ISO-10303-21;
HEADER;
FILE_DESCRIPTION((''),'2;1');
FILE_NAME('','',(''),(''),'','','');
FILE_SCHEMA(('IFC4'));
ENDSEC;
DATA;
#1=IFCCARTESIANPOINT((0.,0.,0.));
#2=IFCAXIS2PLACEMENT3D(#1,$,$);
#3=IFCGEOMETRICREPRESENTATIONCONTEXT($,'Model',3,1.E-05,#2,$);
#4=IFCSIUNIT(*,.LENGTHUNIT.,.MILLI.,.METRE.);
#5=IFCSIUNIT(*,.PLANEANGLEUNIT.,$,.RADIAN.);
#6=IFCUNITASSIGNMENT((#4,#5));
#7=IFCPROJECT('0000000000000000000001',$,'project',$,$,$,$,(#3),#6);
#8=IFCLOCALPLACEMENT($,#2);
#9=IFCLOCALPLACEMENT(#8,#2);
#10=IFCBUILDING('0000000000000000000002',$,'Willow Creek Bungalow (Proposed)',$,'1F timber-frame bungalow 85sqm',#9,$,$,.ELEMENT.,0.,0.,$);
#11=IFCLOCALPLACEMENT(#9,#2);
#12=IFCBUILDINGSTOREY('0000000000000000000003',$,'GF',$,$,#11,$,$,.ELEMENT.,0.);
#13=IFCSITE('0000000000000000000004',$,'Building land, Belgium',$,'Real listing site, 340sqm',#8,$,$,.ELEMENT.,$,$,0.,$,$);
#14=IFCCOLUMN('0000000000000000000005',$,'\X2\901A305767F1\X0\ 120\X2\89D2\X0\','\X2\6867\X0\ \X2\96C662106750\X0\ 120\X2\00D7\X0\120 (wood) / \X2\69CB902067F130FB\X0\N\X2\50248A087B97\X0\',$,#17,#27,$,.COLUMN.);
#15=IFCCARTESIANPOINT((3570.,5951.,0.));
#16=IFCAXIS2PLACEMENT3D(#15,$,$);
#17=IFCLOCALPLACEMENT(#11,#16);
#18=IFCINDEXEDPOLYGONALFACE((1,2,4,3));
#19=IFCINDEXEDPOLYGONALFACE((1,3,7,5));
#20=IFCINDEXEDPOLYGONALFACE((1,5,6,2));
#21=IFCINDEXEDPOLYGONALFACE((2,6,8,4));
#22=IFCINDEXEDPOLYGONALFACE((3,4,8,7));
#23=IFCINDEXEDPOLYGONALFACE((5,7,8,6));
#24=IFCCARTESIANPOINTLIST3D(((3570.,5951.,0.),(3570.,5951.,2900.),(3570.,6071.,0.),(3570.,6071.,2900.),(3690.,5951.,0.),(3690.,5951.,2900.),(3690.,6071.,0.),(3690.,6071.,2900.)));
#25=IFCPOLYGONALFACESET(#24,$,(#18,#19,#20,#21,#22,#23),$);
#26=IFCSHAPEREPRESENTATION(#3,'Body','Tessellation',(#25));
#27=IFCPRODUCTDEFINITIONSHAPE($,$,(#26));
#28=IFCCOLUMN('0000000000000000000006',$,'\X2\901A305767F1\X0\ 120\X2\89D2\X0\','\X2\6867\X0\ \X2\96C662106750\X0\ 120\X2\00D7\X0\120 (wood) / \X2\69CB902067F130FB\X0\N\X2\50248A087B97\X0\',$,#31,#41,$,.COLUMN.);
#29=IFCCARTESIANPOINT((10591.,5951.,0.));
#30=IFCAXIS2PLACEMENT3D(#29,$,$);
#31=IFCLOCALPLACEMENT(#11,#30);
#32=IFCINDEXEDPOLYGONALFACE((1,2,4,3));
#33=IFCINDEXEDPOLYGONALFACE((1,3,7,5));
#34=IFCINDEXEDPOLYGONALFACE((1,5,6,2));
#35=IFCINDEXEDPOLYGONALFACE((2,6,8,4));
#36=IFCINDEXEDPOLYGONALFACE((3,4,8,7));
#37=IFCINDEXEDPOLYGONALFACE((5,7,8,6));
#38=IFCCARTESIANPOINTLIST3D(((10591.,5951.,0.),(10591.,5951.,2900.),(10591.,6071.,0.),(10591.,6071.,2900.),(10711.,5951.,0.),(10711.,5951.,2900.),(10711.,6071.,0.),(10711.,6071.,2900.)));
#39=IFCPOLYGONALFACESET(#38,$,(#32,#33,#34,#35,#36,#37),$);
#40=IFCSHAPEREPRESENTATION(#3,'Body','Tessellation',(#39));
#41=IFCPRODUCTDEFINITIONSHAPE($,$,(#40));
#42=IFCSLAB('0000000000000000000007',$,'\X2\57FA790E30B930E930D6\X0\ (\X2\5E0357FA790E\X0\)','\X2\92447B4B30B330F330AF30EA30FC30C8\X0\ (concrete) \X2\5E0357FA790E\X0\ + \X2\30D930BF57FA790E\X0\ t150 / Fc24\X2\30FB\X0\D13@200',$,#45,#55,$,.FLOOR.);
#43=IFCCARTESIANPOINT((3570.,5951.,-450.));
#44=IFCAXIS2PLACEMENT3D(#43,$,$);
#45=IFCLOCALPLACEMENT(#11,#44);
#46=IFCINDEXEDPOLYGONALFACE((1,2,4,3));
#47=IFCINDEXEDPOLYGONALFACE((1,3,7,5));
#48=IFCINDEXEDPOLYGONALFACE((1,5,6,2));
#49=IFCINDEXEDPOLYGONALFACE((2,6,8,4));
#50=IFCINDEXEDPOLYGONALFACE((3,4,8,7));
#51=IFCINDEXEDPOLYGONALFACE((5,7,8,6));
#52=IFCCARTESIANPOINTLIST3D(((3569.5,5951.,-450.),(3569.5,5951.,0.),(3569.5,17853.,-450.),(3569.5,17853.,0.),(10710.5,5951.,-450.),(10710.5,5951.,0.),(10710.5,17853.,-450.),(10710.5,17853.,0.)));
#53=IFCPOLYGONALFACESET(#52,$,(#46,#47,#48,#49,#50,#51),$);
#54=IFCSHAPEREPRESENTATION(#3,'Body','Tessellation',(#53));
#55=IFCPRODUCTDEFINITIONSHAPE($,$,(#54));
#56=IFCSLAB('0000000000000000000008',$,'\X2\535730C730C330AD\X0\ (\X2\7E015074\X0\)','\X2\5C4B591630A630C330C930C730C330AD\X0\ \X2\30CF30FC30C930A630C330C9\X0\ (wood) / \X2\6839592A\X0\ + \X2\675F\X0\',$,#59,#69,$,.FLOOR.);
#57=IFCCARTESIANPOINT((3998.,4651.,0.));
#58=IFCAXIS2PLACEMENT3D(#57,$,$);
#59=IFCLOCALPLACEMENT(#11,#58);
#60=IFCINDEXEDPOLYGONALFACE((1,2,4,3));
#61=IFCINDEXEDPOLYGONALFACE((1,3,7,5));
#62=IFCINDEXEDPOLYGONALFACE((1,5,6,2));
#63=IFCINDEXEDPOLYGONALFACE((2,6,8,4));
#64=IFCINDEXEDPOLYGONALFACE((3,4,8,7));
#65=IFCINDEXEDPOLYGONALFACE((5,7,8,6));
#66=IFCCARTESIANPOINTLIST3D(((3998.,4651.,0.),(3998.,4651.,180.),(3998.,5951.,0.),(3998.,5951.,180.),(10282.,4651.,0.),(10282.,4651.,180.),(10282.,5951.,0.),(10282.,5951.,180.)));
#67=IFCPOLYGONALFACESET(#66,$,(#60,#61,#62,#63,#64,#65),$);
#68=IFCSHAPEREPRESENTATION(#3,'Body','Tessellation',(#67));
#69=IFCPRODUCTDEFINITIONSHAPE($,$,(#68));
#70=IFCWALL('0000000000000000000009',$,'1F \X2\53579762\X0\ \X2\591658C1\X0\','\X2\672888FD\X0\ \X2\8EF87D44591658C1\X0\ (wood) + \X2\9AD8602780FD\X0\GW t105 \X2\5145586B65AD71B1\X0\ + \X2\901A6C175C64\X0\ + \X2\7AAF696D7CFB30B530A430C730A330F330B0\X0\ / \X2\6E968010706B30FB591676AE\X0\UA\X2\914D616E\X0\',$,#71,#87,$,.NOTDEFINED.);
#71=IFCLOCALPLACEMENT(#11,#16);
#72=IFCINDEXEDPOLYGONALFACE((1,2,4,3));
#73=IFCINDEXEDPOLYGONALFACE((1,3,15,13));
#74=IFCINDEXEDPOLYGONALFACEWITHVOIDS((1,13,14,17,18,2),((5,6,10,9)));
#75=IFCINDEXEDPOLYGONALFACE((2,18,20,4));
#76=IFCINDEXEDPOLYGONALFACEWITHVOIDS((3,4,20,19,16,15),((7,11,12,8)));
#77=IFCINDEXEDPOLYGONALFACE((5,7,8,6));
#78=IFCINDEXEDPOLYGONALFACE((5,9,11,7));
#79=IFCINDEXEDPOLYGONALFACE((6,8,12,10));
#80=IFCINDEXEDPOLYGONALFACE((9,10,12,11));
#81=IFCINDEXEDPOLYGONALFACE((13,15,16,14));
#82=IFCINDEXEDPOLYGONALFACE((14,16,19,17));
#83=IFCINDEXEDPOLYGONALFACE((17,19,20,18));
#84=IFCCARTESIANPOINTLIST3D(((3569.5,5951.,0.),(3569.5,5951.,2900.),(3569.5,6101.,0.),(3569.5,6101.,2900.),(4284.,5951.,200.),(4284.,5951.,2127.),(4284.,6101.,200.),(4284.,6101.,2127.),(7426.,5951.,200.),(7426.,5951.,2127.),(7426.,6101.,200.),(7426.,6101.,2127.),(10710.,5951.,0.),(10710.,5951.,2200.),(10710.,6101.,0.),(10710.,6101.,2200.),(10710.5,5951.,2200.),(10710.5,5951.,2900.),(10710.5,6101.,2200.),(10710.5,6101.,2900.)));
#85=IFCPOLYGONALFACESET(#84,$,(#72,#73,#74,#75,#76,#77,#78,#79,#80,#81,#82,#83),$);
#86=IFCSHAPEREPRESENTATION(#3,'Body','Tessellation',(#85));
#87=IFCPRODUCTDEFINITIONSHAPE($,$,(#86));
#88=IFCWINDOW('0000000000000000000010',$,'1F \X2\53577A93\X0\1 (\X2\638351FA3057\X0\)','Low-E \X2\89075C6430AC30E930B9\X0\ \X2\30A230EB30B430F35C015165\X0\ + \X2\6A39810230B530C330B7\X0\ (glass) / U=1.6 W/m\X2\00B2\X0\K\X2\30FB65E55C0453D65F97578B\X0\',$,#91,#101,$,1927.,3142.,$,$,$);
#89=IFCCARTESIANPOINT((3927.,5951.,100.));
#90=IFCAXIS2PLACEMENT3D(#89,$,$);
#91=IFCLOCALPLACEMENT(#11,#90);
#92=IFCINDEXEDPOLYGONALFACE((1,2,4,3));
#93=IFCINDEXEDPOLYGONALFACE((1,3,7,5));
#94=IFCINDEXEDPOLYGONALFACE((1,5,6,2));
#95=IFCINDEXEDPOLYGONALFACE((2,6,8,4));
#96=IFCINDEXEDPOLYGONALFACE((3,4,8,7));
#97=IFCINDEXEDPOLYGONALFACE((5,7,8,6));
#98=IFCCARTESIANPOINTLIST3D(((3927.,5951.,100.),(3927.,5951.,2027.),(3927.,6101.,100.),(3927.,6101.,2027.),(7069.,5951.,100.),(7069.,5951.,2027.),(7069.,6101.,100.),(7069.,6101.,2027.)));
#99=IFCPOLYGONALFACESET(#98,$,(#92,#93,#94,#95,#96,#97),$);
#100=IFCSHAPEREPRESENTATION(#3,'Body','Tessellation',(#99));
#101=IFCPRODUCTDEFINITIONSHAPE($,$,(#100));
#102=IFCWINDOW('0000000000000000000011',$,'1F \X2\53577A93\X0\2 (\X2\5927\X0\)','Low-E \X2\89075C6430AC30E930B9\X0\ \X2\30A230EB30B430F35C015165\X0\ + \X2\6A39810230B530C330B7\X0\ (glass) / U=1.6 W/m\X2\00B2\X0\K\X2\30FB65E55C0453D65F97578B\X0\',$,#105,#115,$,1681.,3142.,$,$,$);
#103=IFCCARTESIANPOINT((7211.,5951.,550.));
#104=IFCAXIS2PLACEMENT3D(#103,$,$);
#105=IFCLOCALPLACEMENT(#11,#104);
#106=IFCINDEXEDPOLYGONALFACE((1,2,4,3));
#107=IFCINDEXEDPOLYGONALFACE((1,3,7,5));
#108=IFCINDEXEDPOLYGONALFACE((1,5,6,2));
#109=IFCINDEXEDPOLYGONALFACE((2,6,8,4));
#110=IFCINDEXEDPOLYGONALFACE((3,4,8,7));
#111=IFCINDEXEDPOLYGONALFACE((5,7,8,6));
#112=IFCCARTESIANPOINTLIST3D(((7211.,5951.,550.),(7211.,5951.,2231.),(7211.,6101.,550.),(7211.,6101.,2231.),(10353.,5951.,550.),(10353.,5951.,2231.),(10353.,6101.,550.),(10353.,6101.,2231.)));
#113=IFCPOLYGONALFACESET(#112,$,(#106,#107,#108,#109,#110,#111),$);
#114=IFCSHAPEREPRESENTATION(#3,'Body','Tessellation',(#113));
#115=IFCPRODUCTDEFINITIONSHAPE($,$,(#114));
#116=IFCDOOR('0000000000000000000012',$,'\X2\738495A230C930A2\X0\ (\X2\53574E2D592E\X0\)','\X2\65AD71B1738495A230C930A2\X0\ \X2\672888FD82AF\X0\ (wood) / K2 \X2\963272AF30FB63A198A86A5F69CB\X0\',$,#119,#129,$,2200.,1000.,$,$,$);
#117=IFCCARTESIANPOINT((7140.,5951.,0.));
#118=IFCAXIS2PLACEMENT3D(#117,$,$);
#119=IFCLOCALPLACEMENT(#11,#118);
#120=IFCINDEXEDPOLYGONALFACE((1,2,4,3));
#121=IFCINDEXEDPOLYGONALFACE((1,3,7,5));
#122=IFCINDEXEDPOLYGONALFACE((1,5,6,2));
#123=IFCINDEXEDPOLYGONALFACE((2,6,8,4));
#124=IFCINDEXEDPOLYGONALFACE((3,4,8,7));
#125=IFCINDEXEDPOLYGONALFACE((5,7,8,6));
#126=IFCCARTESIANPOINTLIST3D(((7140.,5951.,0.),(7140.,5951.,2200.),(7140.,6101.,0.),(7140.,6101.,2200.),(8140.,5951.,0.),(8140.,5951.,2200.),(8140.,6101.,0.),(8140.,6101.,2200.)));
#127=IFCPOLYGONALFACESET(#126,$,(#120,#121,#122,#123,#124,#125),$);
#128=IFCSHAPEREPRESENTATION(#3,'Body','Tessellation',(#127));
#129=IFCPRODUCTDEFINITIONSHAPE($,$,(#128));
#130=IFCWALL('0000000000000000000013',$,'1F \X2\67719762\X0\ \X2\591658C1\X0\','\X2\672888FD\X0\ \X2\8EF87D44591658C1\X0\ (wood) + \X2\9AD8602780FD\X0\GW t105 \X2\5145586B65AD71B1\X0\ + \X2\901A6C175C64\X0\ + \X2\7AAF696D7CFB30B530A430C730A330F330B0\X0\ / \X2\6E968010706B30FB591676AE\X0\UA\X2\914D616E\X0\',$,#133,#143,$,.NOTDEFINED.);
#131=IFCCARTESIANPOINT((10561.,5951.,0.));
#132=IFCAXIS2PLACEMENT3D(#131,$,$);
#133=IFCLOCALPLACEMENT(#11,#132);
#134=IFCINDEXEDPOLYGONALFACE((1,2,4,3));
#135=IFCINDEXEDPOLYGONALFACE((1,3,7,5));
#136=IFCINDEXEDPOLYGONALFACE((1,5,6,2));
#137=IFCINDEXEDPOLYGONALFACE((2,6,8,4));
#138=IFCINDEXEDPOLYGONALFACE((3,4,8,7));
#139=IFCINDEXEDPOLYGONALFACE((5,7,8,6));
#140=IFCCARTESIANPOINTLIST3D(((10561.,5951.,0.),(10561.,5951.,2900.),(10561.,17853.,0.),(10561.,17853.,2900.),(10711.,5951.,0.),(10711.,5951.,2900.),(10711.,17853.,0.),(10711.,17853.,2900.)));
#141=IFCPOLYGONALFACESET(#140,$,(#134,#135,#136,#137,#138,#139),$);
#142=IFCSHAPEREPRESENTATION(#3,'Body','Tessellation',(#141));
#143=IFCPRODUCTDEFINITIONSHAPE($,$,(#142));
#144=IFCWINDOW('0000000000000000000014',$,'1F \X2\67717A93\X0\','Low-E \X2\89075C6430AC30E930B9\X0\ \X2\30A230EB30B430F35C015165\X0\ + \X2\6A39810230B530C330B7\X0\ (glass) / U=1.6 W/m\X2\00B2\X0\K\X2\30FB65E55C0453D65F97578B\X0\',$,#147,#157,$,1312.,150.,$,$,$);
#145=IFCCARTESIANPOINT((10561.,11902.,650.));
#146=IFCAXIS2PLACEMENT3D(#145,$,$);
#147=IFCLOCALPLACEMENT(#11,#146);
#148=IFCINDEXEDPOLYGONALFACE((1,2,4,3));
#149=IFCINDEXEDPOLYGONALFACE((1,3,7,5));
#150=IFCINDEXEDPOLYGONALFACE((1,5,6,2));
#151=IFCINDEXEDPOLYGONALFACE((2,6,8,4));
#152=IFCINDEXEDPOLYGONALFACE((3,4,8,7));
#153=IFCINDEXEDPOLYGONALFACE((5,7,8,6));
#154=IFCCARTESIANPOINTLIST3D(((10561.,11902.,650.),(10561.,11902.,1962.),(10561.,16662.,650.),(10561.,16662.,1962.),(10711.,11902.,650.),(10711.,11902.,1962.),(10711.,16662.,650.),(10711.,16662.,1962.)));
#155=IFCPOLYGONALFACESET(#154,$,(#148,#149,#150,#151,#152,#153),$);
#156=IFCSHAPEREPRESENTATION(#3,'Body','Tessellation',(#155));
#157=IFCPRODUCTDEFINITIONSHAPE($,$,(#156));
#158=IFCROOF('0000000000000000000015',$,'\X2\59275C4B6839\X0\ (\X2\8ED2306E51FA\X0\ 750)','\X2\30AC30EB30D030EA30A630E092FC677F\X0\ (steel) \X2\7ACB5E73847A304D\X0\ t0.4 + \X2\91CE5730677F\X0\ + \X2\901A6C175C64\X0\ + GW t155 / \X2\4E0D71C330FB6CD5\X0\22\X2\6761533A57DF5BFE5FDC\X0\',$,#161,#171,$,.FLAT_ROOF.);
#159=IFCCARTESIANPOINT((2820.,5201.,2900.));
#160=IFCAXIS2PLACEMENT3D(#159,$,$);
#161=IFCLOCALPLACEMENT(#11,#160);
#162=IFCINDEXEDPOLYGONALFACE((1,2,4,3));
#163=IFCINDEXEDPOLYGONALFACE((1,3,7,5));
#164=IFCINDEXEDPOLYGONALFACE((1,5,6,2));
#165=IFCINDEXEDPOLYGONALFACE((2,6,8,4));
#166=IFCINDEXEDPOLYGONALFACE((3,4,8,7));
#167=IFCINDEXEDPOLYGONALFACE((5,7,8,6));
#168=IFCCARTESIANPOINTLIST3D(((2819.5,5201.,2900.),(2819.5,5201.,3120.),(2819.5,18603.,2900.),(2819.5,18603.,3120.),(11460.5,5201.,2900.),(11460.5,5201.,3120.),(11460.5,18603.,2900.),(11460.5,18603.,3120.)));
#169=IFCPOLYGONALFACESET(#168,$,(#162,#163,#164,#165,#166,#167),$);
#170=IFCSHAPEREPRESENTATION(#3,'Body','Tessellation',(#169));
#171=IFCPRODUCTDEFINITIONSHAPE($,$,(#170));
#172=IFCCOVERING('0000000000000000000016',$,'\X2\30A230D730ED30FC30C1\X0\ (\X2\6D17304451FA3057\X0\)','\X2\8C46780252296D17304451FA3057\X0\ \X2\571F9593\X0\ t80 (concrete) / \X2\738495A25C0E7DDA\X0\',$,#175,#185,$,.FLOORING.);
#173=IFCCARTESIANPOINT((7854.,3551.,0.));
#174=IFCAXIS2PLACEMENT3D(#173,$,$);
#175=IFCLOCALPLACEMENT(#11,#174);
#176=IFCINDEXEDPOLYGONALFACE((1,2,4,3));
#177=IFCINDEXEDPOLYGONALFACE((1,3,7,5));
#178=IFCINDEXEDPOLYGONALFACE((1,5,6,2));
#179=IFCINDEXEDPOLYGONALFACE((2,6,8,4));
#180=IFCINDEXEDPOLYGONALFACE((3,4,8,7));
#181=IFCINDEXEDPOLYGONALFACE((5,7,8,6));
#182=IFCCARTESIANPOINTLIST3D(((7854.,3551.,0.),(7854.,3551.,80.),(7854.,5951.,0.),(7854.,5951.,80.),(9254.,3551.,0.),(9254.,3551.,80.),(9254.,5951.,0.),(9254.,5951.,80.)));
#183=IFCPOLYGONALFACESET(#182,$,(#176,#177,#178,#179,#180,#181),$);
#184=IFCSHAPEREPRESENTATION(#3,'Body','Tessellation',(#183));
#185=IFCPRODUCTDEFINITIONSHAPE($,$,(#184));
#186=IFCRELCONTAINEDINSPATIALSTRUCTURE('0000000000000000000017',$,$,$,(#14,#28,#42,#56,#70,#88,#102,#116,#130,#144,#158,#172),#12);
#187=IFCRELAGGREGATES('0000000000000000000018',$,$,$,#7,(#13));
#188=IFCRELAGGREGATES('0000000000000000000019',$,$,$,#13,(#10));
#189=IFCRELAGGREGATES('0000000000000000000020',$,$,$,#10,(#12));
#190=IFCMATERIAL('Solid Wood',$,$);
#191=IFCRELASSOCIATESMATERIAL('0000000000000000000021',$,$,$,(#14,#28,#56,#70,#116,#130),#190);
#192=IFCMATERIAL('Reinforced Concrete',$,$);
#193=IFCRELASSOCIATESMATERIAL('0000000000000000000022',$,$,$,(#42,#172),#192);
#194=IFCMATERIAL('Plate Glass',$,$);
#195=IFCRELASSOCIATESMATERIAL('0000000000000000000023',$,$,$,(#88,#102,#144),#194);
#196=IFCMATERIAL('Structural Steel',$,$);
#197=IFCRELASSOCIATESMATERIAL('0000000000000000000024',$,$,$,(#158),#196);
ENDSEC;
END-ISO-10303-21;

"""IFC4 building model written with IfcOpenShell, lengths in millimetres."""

from ifc_helpers import new_model, si_unit, frame, frame_2d, origin, place, context, project, spatial, rectangle, extrude, material, element, fill, save


model = new_model("IFC4")

# Units and contexts
model_context = context("Model", 3, precision=1e-05, world=origin())
ifc_project = project(units=[si_unit("LENGTHUNIT", "METRE", prefix="MILLI"), si_unit("PLANEANGLEUNIT", "RADIAN")], contexts=[model_context])

# Site, building, storey
site_placement = place(None, origin())
site = spatial("IfcSite", under=ifc_project, at=site_placement, Name="Building land, Belgium", ObjectType="Real listing site, 340sqm", CompositionType="ELEMENT", RefElevation=0.0)
building_placement = place(site_placement, origin())
building = spatial("IfcBuilding", under=site, at=building_placement, Name="Willow Creek Bungalow (Proposed)", ObjectType="1F timber-frame bungalow 85sqm", CompositionType="ELEMENT", ElevationOfRefHeight=0.0, ElevationOfTerrain=0.0)
storey_placement = place(building_placement, origin())
storey = spatial("IfcBuildingStorey", under=building, at=storey_placement, Name="GF", CompositionType="ELEMENT", Elevation=0.0)

# Columns
ifc_material_1 = material(Name="Solid Wood")
column_1_placement = place(storey_placement, frame((3570.0, 5951.0, 0.0)))
element("IfcColumn", 1, at=column_1_placement, inside=storey, material=ifc_material_1, Name="通し柱 120角", Description="桧 集成材 120×120 (wood) / 構造柱・N値計算", PredefinedType="COLUMN", context=model_context, shape_type="SweptSolid", body=[
    extrude(rectangle(XDim=120.0, YDim=120.0, at=frame_2d((60.0, 60.0))), frame((3570.0, 5951.0, 0.0)), (0.0, 0.0, 1.0), 2900.0),
])
column_2_placement = place(storey_placement, frame((10591.0, 5951.0, 0.0)))
element("IfcColumn", 2, at=column_2_placement, inside=storey, material=ifc_material_1, Name="通し柱 120角", Description="桧 集成材 120×120 (wood) / 構造柱・N値計算", PredefinedType="COLUMN", context=model_context, shape_type="SweptSolid", body=[
    extrude(rectangle(XDim=120.0, YDim=120.0, at=frame_2d((60.0, 60.0))), frame((10591.0, 5951.0, 0.0)), (0.0, 0.0, 1.0), 2900.0),
])

# Slabs
ifc_material_2 = material(Name="Reinforced Concrete")
slab_1_placement = place(storey_placement, frame((3570.0, 5951.0, -450.0)))
element("IfcSlab", 3, at=slab_1_placement, inside=storey, material=ifc_material_2, Name="基礎スラブ (布基礎)", Description="鉄筋コンクリート (concrete) 布基礎 + ベタ基礎 t150 / Fc24・D13@200", PredefinedType="FLOOR", context=model_context, shape_type="SweptSolid", body=[
    extrude(rectangle(XDim=7141.0, YDim=11902.0, at=frame_2d((3570.0, 5951.0))), frame((3570.0, 5951.0, -450.0)), (0.0, 0.0, 1.0), 450.0),
])
slab_2_placement = place(storey_placement, frame((3998.0, 4651.0, 0.0)))
element("IfcSlab", 4, at=slab_2_placement, inside=storey, material=ifc_material_1, Name="南デッキ (縁側)", Description="屋外ウッドデッキ ハードウッド (wood) / 根太 + 束", PredefinedType="FLOOR", context=model_context, shape_type="SweptSolid", body=[
    extrude(rectangle(XDim=6284.0, YDim=1300.0, at=frame_2d((3142.0, 650.0))), frame((3998.0, 4651.0, 0.0)), (0.0, 0.0, 1.0), 180.0),
])

# Wall, openings, windows, door
wall_1_placement = place(storey_placement, frame((3570.0, 5951.0, 0.0)))
wall_1 = element("IfcWall", 5, at=wall_1_placement, inside=storey, material=ifc_material_1, Name="1F 南面 外壁", Description="木製 軸組外壁 (wood) + 高性能GW t105 充填断熱 + 通気層 + 窯業系サイディング / 準耐火・外皮UA配慮", PredefinedType="NOTDEFINED", context=model_context, shape_type="SweptSolid", body=[
    extrude(rectangle(XDim=7141.0, YDim=150.0, at=frame_2d((3570.0, 75.0))), frame((3570.0, 5951.0, 0.0)), (0.0, 0.0, 1.0), 2900.0),
])
opening_1_placement = place(storey_placement, frame((3927.0, 5951.0, 100.0)))
opening_1 = element("IfcOpeningElement", 6, at=opening_1_placement, cuts=wall_1, PredefinedType="NOTDEFINED", context=model_context, shape_type="SweptSolid", body=[
    extrude(rectangle(XDim=3142.0, YDim=150.0, at=frame_2d((1571.0, 75.0))), frame((3927.0, 5951.0, 100.0)), (0.0, 0.0, 1.0), 1927.0),
])
opening_2_placement = place(storey_placement, frame((7211.0, 5951.0, 550.0)))
opening_2 = element("IfcOpeningElement", 7, at=opening_2_placement, cuts=wall_1, PredefinedType="NOTDEFINED", context=model_context, shape_type="SweptSolid", body=[
    extrude(rectangle(XDim=3142.0, YDim=150.0, at=frame_2d((1571.0, 75.0))), frame((7211.0, 5951.0, 550.0)), (0.0, 0.0, 1.0), 1681.0),
])
opening_3_placement = place(storey_placement, frame((7140.0, 5951.0, 0.0)))
opening_3 = element("IfcOpeningElement", 8, at=opening_3_placement, cuts=wall_1, PredefinedType="NOTDEFINED", context=model_context, shape_type="SweptSolid", body=[
    extrude(rectangle(XDim=1000.0, YDim=150.0, at=frame_2d((500.0, 75.0))), frame((7140.0, 5951.0, 0.0)), (0.0, 0.0, 1.0), 2200.0),
])
ifc_material_3 = material(Name="Plate Glass")
window_1_placement = place(storey_placement, frame((3927.0, 5951.0, 100.0)))
window_1 = element("IfcWindow", 9, at=window_1_placement, inside=storey, material=ifc_material_3, Name="1F 南窓1 (掃出し)", Description="Low-E 複層ガラス アルゴン封入 + 樹脂サッシ (glass) / U=1.6 W/m²K・日射取得型", OverallHeight=1927.0, OverallWidth=3142.0, context=model_context, shape_type="SweptSolid", body=[
    extrude(rectangle(XDim=3142.0, YDim=150.0, at=frame_2d((1571.0, 75.0))), frame((3927.0, 5951.0, 100.0)), (0.0, 0.0, 1.0), 1927.0),
])
fill(opening_1, window_1)
window_2_placement = place(storey_placement, frame((7211.0, 5951.0, 550.0)))
window_2 = element("IfcWindow", 10, at=window_2_placement, inside=storey, material=ifc_material_3, Name="1F 南窓2 (大)", Description="Low-E 複層ガラス アルゴン封入 + 樹脂サッシ (glass) / U=1.6 W/m²K・日射取得型", OverallHeight=1681.0, OverallWidth=3142.0, context=model_context, shape_type="SweptSolid", body=[
    extrude(rectangle(XDim=3142.0, YDim=150.0, at=frame_2d((1571.0, 75.0))), frame((7211.0, 5951.0, 550.0)), (0.0, 0.0, 1.0), 1681.0),
])
fill(opening_2, window_2)
door_placement = place(storey_placement, frame((7140.0, 5951.0, 0.0)))
door = element("IfcDoor", 11, at=door_placement, inside=storey, material=ifc_material_1, Name="玄関ドア (南中央)", Description="断熱玄関ドア 木製芯 (wood) / K2 防犯・採風機構", OverallHeight=2200.0, OverallWidth=1000.0, context=model_context, shape_type="SweptSolid", body=[
    extrude(rectangle(XDim=1000.0, YDim=150.0, at=frame_2d((500.0, 75.0))), frame((7140.0, 5951.0, 0.0)), (0.0, 0.0, 1.0), 2200.0),
])
fill(opening_3, door)

# Wall, opening, window
wall_2_placement = place(storey_placement, frame((10561.0, 5951.0, 0.0)))
wall_2 = element("IfcWall", 12, at=wall_2_placement, inside=storey, material=ifc_material_1, Name="1F 東面 外壁", Description="木製 軸組外壁 (wood) + 高性能GW t105 充填断熱 + 通気層 + 窯業系サイディング / 準耐火・外皮UA配慮", PredefinedType="NOTDEFINED", context=model_context, shape_type="SweptSolid", body=[
    extrude(rectangle(XDim=150.0, YDim=11902.0, at=frame_2d((75.0, 5951.0))), frame((10561.0, 5951.0, 0.0)), (0.0, 0.0, 1.0), 2900.0),
])
opening_4_placement = place(storey_placement, frame((10561.0, 11902.0, 650.0)))
opening_4 = element("IfcOpeningElement", 13, at=opening_4_placement, cuts=wall_2, PredefinedType="NOTDEFINED", context=model_context, shape_type="SweptSolid", body=[
    extrude(rectangle(XDim=150.0, YDim=4760.0, at=frame_2d((75.0, 2380.0))), frame((10561.0, 11902.0, 650.0)), (0.0, 0.0, 1.0), 1312.0),
])
window_3_placement = place(storey_placement, frame((10561.0, 11902.0, 650.0)))
window_3 = element("IfcWindow", 14, at=window_3_placement, inside=storey, material=ifc_material_3, Name="1F 東窓", Description="Low-E 複層ガラス アルゴン封入 + 樹脂サッシ (glass) / U=1.6 W/m²K・日射取得型", OverallHeight=1312.0, OverallWidth=150.0, context=model_context, shape_type="SweptSolid", body=[
    extrude(rectangle(XDim=150.0, YDim=4760.0, at=frame_2d((75.0, 2380.0))), frame((10561.0, 11902.0, 650.0)), (0.0, 0.0, 1.0), 1312.0),
])
fill(opening_4, window_3)

# Roof
ifc_material_4 = material(Name="Structural Steel")
roof_placement = place(storey_placement, frame((2820.0, 5201.0, 2900.0)))
element("IfcRoof", 15, at=roof_placement, inside=storey, material=ifc_material_4, Name="大屋根 (軒の出 750)", Description="ガルバリウム鋼板 (steel) 立平葺き t0.4 + 野地板 + 通気層 + GW t155 / 不燃・法22条区域対応", PredefinedType="FLAT_ROOF", context=model_context, shape_type="SweptSolid", body=[
    extrude(rectangle(XDim=8641.0, YDim=13402.0, at=frame_2d((4320.0, 6701.0))), frame((2820.0, 5201.0, 2900.0)), (0.0, 0.0, 1.0), 220.0),
])

# Covering
covering_1_placement = place(storey_placement, frame((7854.0, 3551.0, 0.0)))
element("IfcCovering", 16, at=covering_1_placement, inside=storey, material=ifc_material_2, Name="アプローチ (洗い出し)", Description="豆砂利洗い出し 土間 t80 (concrete) / 玄関導線", PredefinedType="FLOORING", context=model_context, shape_type="SweptSolid", body=[
    extrude(rectangle(XDim=1400.0, YDim=2400.0, at=frame_2d((700.0, 1200.0))), frame((7854.0, 3551.0, 0.0)), (0.0, 0.0, 1.0), 80.0),
])

save(model, "model.ifc")
